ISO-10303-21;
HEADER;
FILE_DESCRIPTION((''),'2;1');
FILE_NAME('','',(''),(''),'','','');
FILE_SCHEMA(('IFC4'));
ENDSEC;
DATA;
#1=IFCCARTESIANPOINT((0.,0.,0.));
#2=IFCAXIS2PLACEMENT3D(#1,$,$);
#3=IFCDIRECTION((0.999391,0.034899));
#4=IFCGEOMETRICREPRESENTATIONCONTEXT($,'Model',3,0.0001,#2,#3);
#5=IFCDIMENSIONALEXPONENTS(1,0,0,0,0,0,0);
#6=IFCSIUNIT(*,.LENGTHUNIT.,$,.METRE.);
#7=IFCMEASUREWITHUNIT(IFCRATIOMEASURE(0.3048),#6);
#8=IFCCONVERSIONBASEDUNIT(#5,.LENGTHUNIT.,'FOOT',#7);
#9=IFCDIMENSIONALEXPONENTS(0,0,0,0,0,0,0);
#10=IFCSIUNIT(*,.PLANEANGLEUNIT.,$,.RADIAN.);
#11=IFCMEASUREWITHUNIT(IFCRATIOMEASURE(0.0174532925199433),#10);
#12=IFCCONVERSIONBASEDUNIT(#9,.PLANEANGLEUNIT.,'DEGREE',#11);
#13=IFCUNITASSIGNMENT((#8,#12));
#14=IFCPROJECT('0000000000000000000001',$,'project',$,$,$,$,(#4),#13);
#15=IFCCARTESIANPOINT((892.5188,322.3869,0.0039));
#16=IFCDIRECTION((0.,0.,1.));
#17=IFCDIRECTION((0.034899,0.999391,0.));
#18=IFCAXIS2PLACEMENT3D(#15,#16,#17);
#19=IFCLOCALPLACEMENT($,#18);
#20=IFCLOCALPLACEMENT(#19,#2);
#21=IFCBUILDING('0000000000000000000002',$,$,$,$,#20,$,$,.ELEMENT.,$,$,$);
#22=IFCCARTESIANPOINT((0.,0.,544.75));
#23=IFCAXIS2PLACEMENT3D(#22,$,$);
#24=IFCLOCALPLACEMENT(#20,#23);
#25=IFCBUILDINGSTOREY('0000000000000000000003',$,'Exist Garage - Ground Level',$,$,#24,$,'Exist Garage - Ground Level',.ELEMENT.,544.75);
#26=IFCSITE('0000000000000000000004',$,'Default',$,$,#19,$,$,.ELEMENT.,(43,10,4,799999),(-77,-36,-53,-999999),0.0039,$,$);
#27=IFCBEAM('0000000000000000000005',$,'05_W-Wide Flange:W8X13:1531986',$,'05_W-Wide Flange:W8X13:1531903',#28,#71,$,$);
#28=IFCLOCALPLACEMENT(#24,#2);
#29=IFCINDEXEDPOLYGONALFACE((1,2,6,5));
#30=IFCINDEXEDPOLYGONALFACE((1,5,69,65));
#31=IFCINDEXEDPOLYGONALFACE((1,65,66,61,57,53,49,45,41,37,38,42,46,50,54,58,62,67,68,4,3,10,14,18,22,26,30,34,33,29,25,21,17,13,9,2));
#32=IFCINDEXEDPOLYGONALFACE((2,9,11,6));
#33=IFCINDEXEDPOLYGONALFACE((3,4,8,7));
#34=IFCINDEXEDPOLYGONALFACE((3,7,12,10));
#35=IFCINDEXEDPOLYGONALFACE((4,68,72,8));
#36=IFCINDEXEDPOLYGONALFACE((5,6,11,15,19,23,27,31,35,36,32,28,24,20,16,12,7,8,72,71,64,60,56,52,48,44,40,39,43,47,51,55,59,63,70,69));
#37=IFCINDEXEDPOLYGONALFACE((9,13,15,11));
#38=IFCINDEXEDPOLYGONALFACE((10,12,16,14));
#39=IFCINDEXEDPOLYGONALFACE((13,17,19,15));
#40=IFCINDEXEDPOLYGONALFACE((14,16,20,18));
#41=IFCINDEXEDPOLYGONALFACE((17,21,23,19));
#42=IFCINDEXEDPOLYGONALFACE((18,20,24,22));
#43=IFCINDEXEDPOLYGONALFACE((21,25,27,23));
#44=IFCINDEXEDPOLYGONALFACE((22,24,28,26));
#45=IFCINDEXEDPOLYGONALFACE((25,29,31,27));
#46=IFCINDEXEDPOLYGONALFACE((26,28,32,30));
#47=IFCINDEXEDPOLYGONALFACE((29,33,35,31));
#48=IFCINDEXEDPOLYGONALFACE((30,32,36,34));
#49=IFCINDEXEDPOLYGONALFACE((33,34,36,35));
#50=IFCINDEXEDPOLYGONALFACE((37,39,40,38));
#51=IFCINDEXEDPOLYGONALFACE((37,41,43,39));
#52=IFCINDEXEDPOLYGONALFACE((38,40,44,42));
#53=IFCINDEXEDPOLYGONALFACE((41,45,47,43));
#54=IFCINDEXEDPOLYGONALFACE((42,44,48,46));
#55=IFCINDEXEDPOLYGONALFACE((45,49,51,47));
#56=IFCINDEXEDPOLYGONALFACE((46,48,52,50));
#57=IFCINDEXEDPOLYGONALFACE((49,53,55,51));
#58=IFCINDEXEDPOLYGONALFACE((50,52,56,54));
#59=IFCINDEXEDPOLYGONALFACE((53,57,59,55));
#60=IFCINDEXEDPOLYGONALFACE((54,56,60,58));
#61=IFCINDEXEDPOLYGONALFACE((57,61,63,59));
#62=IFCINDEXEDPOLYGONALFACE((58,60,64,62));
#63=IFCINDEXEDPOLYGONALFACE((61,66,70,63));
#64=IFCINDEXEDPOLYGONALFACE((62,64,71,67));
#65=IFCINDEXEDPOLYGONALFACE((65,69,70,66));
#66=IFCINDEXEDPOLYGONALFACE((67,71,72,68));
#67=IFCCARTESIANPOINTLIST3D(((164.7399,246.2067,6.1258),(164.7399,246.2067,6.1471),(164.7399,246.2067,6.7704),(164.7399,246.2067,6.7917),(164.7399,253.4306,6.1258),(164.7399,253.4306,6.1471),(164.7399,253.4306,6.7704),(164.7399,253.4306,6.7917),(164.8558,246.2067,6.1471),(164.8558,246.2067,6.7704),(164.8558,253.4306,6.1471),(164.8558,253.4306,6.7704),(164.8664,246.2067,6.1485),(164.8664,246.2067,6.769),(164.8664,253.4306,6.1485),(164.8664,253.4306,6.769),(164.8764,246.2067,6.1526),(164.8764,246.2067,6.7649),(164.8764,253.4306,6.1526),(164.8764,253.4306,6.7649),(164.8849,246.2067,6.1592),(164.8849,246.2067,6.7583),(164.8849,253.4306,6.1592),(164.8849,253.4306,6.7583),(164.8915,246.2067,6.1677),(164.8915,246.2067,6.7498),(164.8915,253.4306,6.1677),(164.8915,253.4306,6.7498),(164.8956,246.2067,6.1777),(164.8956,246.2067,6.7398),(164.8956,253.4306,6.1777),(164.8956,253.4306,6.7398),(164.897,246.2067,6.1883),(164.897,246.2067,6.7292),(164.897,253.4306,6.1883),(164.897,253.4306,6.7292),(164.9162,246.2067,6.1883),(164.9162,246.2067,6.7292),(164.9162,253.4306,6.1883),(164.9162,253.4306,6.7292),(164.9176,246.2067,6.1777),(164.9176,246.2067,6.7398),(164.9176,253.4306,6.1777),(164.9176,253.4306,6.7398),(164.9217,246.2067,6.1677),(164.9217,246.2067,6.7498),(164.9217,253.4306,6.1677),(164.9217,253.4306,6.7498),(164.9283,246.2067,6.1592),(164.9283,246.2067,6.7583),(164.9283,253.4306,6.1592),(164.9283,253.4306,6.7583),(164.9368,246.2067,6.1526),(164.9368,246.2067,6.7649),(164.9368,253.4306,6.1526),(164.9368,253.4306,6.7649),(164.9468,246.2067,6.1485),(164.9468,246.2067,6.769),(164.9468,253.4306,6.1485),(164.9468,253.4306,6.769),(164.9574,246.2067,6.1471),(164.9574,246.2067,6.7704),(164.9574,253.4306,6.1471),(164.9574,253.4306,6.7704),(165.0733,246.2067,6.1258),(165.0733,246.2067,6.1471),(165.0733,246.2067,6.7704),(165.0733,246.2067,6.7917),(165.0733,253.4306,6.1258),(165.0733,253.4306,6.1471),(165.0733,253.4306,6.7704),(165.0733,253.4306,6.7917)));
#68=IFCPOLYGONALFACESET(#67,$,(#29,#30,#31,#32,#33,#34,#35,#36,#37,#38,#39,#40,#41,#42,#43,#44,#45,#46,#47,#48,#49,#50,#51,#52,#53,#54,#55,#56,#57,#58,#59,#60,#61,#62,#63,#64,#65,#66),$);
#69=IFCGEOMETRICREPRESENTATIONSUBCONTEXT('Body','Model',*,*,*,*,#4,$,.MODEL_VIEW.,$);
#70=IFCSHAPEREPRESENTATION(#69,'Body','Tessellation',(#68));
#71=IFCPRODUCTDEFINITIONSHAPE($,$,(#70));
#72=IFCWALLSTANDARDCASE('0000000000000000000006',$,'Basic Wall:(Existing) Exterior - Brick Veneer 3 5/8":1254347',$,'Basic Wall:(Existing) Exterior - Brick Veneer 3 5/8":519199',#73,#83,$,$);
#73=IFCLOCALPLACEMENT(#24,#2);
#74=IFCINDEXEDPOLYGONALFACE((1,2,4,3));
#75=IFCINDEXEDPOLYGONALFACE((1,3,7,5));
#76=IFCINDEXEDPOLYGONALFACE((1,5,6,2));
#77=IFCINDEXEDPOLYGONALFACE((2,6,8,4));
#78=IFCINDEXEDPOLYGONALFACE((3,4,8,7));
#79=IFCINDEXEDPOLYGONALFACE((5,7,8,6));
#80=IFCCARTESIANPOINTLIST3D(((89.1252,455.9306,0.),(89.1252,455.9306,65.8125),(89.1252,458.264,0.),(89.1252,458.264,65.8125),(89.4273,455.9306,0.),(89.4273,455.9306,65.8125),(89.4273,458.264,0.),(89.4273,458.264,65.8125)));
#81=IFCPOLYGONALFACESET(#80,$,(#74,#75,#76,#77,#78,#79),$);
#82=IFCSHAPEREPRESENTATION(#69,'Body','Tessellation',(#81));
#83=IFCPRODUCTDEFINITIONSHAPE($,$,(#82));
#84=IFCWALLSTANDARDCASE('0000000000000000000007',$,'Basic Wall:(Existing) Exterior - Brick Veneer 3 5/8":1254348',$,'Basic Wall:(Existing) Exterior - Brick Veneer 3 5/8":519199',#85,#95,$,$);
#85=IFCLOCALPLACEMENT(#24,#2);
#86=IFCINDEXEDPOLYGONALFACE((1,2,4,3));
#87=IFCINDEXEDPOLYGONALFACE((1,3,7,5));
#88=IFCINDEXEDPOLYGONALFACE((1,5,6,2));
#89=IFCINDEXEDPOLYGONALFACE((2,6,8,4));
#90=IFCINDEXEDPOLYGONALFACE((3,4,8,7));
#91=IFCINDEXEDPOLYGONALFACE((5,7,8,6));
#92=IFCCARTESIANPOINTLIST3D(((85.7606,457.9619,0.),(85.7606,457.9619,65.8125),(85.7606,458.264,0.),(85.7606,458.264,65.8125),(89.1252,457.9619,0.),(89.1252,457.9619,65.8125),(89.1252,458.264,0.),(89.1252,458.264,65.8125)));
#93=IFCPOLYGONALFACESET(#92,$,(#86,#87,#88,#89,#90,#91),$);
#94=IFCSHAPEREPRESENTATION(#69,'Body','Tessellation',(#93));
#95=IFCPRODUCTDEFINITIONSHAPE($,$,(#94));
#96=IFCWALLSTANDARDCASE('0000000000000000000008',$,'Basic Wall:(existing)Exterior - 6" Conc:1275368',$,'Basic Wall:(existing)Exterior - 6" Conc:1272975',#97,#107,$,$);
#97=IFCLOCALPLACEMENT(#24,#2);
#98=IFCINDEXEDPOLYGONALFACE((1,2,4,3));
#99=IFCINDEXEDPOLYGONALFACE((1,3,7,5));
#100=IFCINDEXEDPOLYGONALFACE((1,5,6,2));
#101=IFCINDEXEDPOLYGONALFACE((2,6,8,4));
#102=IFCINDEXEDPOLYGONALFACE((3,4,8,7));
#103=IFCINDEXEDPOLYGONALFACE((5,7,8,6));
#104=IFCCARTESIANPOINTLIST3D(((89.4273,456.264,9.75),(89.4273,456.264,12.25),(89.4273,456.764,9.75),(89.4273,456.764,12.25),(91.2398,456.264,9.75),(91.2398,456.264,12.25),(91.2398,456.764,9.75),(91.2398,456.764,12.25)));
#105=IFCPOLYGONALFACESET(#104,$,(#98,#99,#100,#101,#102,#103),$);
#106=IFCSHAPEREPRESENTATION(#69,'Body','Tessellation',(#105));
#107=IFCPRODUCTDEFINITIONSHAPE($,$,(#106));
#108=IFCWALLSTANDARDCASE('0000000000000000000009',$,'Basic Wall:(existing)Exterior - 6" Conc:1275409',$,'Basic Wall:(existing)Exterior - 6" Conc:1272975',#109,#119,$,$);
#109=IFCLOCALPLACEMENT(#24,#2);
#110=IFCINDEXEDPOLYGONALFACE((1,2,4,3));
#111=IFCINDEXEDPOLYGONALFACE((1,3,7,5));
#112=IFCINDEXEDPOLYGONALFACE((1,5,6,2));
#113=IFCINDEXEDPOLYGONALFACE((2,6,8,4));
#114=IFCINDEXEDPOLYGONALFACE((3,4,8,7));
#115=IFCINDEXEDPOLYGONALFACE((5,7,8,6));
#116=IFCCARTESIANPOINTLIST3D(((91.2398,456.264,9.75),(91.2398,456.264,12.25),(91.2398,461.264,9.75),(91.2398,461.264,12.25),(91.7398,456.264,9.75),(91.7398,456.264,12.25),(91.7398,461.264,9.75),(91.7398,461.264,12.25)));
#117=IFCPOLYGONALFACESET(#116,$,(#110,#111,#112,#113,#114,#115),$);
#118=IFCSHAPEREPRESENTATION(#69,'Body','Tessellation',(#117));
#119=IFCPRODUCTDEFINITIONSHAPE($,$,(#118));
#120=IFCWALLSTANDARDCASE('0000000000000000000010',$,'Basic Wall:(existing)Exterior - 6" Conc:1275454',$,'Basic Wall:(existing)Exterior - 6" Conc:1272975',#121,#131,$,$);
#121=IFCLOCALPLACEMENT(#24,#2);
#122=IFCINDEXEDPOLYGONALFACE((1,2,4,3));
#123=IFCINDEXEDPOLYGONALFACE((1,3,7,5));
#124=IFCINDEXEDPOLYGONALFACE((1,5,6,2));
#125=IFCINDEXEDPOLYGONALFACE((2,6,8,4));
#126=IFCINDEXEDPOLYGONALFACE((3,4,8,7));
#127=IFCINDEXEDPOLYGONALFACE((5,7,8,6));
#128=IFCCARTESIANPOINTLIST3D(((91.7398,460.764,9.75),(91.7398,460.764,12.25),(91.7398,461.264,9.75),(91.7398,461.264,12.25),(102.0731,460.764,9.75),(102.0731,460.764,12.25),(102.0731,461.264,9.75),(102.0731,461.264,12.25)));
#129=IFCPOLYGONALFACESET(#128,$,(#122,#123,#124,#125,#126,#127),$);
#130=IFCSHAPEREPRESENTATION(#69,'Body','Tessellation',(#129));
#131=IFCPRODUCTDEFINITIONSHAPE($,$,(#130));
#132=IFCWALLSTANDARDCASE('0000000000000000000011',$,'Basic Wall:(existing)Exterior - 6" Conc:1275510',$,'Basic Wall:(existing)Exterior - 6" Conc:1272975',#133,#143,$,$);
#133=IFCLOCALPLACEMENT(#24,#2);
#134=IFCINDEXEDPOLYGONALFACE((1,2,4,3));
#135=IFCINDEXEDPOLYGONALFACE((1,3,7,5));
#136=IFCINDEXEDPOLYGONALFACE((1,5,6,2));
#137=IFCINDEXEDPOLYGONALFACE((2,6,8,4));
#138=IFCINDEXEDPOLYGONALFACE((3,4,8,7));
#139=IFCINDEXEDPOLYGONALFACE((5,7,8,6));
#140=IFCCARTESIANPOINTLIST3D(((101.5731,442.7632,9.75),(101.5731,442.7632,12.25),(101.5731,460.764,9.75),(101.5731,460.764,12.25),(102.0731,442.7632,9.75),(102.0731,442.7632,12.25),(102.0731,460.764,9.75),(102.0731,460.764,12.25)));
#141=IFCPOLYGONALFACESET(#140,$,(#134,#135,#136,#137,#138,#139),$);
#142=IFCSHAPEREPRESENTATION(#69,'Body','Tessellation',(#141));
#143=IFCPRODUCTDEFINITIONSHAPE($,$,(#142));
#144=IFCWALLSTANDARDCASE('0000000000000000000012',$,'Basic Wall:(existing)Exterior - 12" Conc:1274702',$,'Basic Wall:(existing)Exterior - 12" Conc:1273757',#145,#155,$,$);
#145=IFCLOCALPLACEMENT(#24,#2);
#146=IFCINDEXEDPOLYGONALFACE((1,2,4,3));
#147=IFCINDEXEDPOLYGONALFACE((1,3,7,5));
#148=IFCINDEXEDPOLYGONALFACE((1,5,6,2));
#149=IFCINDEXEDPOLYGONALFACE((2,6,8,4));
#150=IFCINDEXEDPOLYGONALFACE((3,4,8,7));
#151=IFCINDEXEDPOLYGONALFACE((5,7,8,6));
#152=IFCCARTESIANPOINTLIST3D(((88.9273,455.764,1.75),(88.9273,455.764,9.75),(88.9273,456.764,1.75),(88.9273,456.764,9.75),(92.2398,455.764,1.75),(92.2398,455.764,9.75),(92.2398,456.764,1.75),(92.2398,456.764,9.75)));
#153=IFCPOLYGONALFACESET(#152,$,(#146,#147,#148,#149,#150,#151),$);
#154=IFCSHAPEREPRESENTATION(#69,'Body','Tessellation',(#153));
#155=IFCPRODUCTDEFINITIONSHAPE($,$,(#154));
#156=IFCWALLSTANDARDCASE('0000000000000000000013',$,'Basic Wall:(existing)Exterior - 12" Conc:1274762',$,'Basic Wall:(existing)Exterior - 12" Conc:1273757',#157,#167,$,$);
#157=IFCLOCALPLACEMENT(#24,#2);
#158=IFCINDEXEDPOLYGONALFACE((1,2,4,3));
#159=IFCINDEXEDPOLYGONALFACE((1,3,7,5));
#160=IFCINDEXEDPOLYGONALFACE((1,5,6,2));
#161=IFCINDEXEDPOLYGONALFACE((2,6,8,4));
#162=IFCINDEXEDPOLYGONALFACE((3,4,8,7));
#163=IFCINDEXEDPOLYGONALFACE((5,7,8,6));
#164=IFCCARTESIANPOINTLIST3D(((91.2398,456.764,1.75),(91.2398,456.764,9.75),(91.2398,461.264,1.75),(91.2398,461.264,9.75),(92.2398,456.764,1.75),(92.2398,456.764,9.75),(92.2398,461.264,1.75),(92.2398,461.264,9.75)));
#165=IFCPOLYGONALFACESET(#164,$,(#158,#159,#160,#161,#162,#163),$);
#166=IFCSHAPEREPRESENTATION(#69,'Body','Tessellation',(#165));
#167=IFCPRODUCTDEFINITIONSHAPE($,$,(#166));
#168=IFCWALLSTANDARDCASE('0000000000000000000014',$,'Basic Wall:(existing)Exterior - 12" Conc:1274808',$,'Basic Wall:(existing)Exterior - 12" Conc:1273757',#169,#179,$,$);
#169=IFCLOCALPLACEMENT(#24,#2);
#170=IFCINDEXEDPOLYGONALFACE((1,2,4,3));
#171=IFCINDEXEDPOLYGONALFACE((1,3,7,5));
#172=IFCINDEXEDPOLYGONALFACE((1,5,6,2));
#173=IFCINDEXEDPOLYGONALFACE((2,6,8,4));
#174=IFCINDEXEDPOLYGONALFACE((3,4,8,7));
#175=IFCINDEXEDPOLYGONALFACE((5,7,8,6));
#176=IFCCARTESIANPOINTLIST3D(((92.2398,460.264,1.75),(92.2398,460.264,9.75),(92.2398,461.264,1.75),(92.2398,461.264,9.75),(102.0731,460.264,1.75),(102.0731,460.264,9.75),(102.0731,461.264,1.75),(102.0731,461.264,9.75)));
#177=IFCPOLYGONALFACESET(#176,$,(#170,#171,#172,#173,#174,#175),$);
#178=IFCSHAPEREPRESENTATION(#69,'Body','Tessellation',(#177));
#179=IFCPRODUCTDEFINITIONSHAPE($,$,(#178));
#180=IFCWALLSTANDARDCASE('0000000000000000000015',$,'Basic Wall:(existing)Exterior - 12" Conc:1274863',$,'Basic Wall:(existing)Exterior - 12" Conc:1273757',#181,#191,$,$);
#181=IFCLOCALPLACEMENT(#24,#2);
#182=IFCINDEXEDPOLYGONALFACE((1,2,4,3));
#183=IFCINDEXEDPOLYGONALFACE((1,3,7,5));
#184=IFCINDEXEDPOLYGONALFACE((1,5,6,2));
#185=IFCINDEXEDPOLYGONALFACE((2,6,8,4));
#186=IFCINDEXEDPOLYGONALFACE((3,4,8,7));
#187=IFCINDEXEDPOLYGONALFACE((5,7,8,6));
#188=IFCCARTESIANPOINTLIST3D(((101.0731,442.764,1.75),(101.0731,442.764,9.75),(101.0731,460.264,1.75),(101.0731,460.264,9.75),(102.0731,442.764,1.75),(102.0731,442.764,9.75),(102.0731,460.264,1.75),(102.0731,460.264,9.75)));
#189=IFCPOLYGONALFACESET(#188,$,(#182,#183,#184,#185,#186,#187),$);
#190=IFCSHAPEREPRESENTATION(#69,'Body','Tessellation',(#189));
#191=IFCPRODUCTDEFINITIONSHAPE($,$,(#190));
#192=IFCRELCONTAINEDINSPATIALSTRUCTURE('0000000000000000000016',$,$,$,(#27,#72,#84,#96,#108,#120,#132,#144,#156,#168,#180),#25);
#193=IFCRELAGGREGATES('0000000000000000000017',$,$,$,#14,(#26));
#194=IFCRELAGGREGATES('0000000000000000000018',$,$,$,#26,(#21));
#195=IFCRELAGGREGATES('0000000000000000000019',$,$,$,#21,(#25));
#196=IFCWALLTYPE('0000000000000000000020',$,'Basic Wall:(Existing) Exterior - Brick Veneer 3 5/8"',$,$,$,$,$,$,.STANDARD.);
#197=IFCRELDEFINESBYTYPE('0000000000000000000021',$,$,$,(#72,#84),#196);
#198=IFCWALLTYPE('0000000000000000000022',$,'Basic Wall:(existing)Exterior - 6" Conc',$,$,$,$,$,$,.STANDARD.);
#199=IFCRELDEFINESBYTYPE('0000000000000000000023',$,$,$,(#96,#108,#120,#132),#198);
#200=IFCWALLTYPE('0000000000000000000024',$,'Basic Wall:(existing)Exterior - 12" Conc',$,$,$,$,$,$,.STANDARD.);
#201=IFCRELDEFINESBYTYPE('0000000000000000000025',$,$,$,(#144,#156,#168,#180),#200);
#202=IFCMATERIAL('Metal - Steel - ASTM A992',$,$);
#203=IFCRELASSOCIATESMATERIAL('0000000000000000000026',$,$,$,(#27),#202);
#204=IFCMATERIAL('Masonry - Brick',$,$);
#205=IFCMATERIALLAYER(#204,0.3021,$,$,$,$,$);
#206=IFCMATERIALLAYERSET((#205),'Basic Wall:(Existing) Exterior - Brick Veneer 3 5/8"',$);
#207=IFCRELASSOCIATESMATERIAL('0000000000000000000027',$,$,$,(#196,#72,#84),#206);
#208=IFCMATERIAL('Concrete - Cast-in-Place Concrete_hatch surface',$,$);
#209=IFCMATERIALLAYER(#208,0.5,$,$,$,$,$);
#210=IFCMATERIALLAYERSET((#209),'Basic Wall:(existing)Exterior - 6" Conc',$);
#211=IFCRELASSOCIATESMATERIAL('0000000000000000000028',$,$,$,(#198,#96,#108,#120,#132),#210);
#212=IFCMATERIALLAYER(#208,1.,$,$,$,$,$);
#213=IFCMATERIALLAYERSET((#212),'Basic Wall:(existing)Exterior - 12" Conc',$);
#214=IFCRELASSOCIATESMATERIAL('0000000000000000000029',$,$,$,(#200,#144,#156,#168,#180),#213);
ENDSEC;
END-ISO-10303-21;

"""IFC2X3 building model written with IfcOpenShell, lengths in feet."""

from ifc_helpers import new_model, entity, si_unit, converted_unit, direction, frame, frame_2d, origin, place, context, subcontext, project, spatial, rectangle, i_section, extrude, material, layer, layer_set, layer_usage, type_object, element, save


model = new_model("IFC2X3")

# Units and contexts
model_context = context("Model", 3, precision=0.0001, world=origin(), true_north=direction((0.999391, 0.034899)))
body_context = subcontext(model_context, "Body", "Model", "MODEL_VIEW")
ifc_project = project(units=[converted_unit("LENGTHUNIT", "FOOT", entity("IfcRatioMeasure", 0.3048), si_unit("LENGTHUNIT", "METRE"), dimensions=[1, 0, 0, 0, 0, 0, 0]), converted_unit("PLANEANGLEUNIT", "DEGREE", entity("IfcRatioMeasure", 0.0174532925199433), si_unit("PLANEANGLEUNIT", "RADIAN"), dimensions=[0, 0, 0, 0, 0, 0, 0])], contexts=[model_context])

# Site, building, storey
site_placement = place(None, frame((892.5188, 322.3869, 0.0039), z_axis=(0.0, 0.0, 1.0), x_axis=(0.034899, 0.999391, 0.0)))
site = spatial("IfcSite", under=ifc_project, at=site_placement, Name="Default", CompositionType="ELEMENT", RefLatitude=(43, 10, 4, 799999), RefLongitude=(-77, -36, -53, -999999), RefElevation=0.0039)
building_placement = place(site_placement, origin())
building = spatial("IfcBuilding", under=site, at=building_placement, CompositionType="ELEMENT")
storey_placement = place(building_placement, frame((0.0, 0.0, 544.75)))
storey = spatial("IfcBuildingStorey", under=building, at=storey_placement, Name="Exist Garage - Ground Level", LongName="Exist Garage - Ground Level", CompositionType="ELEMENT", Elevation=544.75)

# Beam
ifc_material_1 = material(Name="Metal - Steel - ASTM A992")
beam_placement = place(storey_placement, frame((164.9066, 253.4306, 6.7917), z_axis=(0.0, 0.0, 1.0), x_axis=(0.0, -1.0, 0.0)))
element("IfcBeam", 1, at=beam_placement, inside=storey, material=ifc_material_1, Name="05_W-Wide Flange:W8X13:1531986", ObjectType="05_W-Wide Flange:W8X13:1531903", context=body_context, shape_type="SweptSolid", body=[
    extrude(i_section(OverallWidth=0.3333, OverallDepth=0.6658, WebThickness=0.0192, FlangeThickness=0.0213, FilletRadius=0.0412, at=frame_2d((0.0, 0.0), x_axis=(0.0, 1.0))), frame((0.0, 0.0, -0.3329), z_axis=(1.0, 0.0, 0.0), x_axis=(0.0, 0.0, -1.0)), (0.0, 0.0, 1.0), 7.224),
])

# Walls
ifc_material_2 = material(Name="Masonry - Brick")
ifc_layer_1 = layer(ifc_material_2, 0.3021)
ifc_layer_set_1 = layer_set([ifc_layer_1], Name="Basic Wall:(Existing) Exterior - Brick Veneer 3 5/8\"")
ifc_layer_usage_1 = layer_usage(ifc_layer_set_1, "AXIS2", "POSITIVE", -0.151)
wall_type_1 = type_object("IfcWallType", Name="Basic Wall:(Existing) Exterior - Brick Veneer 3 5/8\"", PredefinedType="STANDARD", material=ifc_layer_set_1)
wall_1_placement = place(storey_placement, frame((89.2763, 455.9306, 0.0), z_axis=(0.0, 0.0, 1.0), x_axis=(0.0, 1.0, 0.0)))
element("IfcWallStandardCase", 2, at=wall_1_placement, inside=storey, type_object=wall_type_1, material=ifc_layer_usage_1, Name="Basic Wall:(Existing) Exterior - Brick Veneer 3 5/8\":1254347", ObjectType="Basic Wall:(Existing) Exterior - Brick Veneer 3 5/8\":519199", context=body_context, shape_type="SweptSolid", body=[
    extrude(rectangle(XDim=2.3333, YDim=0.3021, at=frame_2d((1.1667, 0.0), x_axis=(-1.0, 0.0))), origin(), (0.0, 0.0, 1.0), 65.8125),
])
ifc_layer_usage_2 = layer_usage(ifc_layer_set_1, "AXIS2", "POSITIVE", -0.151)
wall_2_placement = place(storey_placement, frame((89.1252, 458.1129, 0.0), z_axis=(0.0, 0.0, 1.0), x_axis=(-1.0, 0.0, 0.0)))
element("IfcWallStandardCase", 3, at=wall_2_placement, inside=storey, type_object=wall_type_1, material=ifc_layer_usage_2, Name="Basic Wall:(Existing) Exterior - Brick Veneer 3 5/8\":1254348", ObjectType="Basic Wall:(Existing) Exterior - Brick Veneer 3 5/8\":519199", context=body_context, shape_type="SweptSolid", body=[
    extrude(rectangle(XDim=3.3646, YDim=0.3021, at=frame_2d((1.6823, 0.0), x_axis=(-1.0, 0.0))), origin(), (0.0, 0.0, 1.0), 65.8125),
])
ifc_material_3 = material(Name="Concrete - Cast-in-Place Concrete_hatch surface")
ifc_layer_2 = layer(ifc_material_3, 0.5)
ifc_layer_set_2 = layer_set([ifc_layer_2], Name="Basic Wall:(existing)Exterior - 6\" Conc")
ifc_layer_usage_3 = layer_usage(ifc_layer_set_2, "AXIS2", "NEGATIVE", 0.25)
wall_type_2 = type_object("IfcWallType", Name="Basic Wall:(existing)Exterior - 6\" Conc", PredefinedType="STANDARD", material=ifc_layer_set_2)
wall_3_placement = place(storey_placement, frame((89.4273, 456.514, 9.75)))
element("IfcWallStandardCase", 4, at=wall_3_placement, inside=storey, type_object=wall_type_2, material=ifc_layer_usage_3, Name="Basic Wall:(existing)Exterior - 6\" Conc:1275368", ObjectType="Basic Wall:(existing)Exterior - 6\" Conc:1272975", context=body_context, shape_type="SweptSolid", body=[
    extrude(rectangle(XDim=1.8125, YDim=0.5, at=frame_2d((0.9062, 0.0), x_axis=(-1.0, 0.0))), origin(), (0.0, 0.0, 1.0), 2.5),
])
ifc_layer_usage_4 = layer_usage(ifc_layer_set_2, "AXIS2", "NEGATIVE", 0.25)
wall_4_placement = place(storey_placement, frame((91.4898, 456.264, 9.75), z_axis=(0.0, 0.0, 1.0), x_axis=(0.0, 1.0, 0.0)))
element("IfcWallStandardCase", 5, at=wall_4_placement, inside=storey, type_object=wall_type_2, material=ifc_layer_usage_4, Name="Basic Wall:(existing)Exterior - 6\" Conc:1275409", ObjectType="Basic Wall:(existing)Exterior - 6\" Conc:1272975", context=body_context, shape_type="SweptSolid", body=[
    extrude(rectangle(XDim=5.0, YDim=0.5, at=frame_2d((2.5, 0.0), x_axis=(-1.0, 0.0))), origin(), (0.0, 0.0, 1.0), 2.5),
])
ifc_layer_usage_5 = layer_usage(ifc_layer_set_2, "AXIS2", "NEGATIVE", 0.25)
wall_5_placement = place(storey_placement, frame((91.7398, 461.014, 9.75)))
element("IfcWallStandardCase", 6, at=wall_5_placement, inside=storey, type_object=wall_type_2, material=ifc_layer_usage_5, Name="Basic Wall:(existing)Exterior - 6\" Conc:1275454", ObjectType="Basic Wall:(existing)Exterior - 6\" Conc:1272975", context=body_context, shape_type="SweptSolid", body=[
    extrude(rectangle(XDim=10.3333, YDim=0.5, at=frame_2d((5.1667, 0.0), x_axis=(-1.0, 0.0))), origin(), (0.0, 0.0, 1.0), 2.5),
])
ifc_layer_usage_6 = layer_usage(ifc_layer_set_2, "AXIS2", "NEGATIVE", 0.25)
wall_6_placement = place(storey_placement, frame((101.8231, 460.764, 9.75), z_axis=(0.0, 0.0, 1.0), x_axis=(0.0, -1.0, 0.0)))
element("IfcWallStandardCase", 7, at=wall_6_placement, inside=storey, type_object=wall_type_2, material=ifc_layer_usage_6, Name="Basic Wall:(existing)Exterior - 6\" Conc:1275510", ObjectType="Basic Wall:(existing)Exterior - 6\" Conc:1272975", context=body_context, shape_type="SweptSolid", body=[
    extrude(rectangle(XDim=18.0008, YDim=0.5, at=frame_2d((9.0004, 0.0), x_axis=(-1.0, 0.0))), origin(), (0.0, 0.0, 1.0), 2.5),
])
ifc_layer_3 = layer(ifc_material_3, 1.0)
ifc_layer_set_3 = layer_set([ifc_layer_3], Name="Basic Wall:(existing)Exterior - 12\" Conc")
ifc_layer_usage_7 = layer_usage(ifc_layer_set_3, "AXIS2", "POSITIVE", -0.5)
wall_type_3 = type_object("IfcWallType", Name="Basic Wall:(existing)Exterior - 12\" Conc", PredefinedType="STANDARD", material=ifc_layer_set_3)
wall_7_placement = place(storey_placement, frame((88.9273, 456.264, 1.75)))
element("IfcWallStandardCase", 8, at=wall_7_placement, inside=storey, type_object=wall_type_3, material=ifc_layer_usage_7, Name="Basic Wall:(existing)Exterior - 12\" Conc:1274702", ObjectType="Basic Wall:(existing)Exterior - 12\" Conc:1273757", context=body_context, shape_type="SweptSolid", body=[
    extrude(rectangle(XDim=3.3125, YDim=1.0, at=frame_2d((1.6563, 0.0), x_axis=(-1.0, 0.0))), origin(), (0.0, 0.0, 1.0), 8.0),
])
ifc_layer_usage_8 = layer_usage(ifc_layer_set_3, "AXIS2", "NEGATIVE", 0.5)
wall_8_placement = place(storey_placement, frame((91.7398, 456.764, 1.75), z_axis=(0.0, 0.0, 1.0), x_axis=(0.0, 1.0, 0.0)))
element("IfcWallStandardCase", 9, at=wall_8_placement, inside=storey, type_object=wall_type_3, material=ifc_layer_usage_8, Name="Basic Wall:(existing)Exterior - 12\" Conc:1274762", ObjectType="Basic Wall:(existing)Exterior - 12\" Conc:1273757", context=body_context, shape_type="SweptSolid", body=[
    extrude(rectangle(XDim=4.5, YDim=1.0, at=frame_2d((2.25, 0.0), x_axis=(-1.0, 0.0))), origin(), (0.0, 0.0, 1.0), 8.0),
])
ifc_layer_usage_9 = layer_usage(ifc_layer_set_3, "AXIS2", "NEGATIVE", 0.5)
wall_9_placement = place(storey_placement, frame((92.2398, 460.764, 1.75)))
element("IfcWallStandardCase", 10, at=wall_9_placement, inside=storey, type_object=wall_type_3, material=ifc_layer_usage_9, Name="Basic Wall:(existing)Exterior - 12\" Conc:1274808", ObjectType="Basic Wall:(existing)Exterior - 12\" Conc:1273757", context=body_context, shape_type="SweptSolid", body=[
    extrude(rectangle(XDim=9.8333, YDim=1.0, at=frame_2d((4.9167, 0.0), x_axis=(-1.0, 0.0))), origin(), (0.0, 0.0, 1.0), 8.0),
])
ifc_layer_usage_10 = layer_usage(ifc_layer_set_3, "AXIS2", "NEGATIVE", 0.5)
wall_10_placement = place(storey_placement, frame((101.5731, 460.264, 1.75), z_axis=(0.0, 0.0, 1.0), x_axis=(0.0, -1.0, 0.0)))
element("IfcWallStandardCase", 11, at=wall_10_placement, inside=storey, type_object=wall_type_3, material=ifc_layer_usage_10, Name="Basic Wall:(existing)Exterior - 12\" Conc:1274863", ObjectType="Basic Wall:(existing)Exterior - 12\" Conc:1273757", context=body_context, shape_type="SweptSolid", body=[
    extrude(rectangle(XDim=17.5, YDim=1.0, at=frame_2d((8.75, 0.0), x_axis=(-1.0, 0.0))), origin(), (0.0, 0.0, 1.0), 8.0),
])

save(model, "model.ifc")
